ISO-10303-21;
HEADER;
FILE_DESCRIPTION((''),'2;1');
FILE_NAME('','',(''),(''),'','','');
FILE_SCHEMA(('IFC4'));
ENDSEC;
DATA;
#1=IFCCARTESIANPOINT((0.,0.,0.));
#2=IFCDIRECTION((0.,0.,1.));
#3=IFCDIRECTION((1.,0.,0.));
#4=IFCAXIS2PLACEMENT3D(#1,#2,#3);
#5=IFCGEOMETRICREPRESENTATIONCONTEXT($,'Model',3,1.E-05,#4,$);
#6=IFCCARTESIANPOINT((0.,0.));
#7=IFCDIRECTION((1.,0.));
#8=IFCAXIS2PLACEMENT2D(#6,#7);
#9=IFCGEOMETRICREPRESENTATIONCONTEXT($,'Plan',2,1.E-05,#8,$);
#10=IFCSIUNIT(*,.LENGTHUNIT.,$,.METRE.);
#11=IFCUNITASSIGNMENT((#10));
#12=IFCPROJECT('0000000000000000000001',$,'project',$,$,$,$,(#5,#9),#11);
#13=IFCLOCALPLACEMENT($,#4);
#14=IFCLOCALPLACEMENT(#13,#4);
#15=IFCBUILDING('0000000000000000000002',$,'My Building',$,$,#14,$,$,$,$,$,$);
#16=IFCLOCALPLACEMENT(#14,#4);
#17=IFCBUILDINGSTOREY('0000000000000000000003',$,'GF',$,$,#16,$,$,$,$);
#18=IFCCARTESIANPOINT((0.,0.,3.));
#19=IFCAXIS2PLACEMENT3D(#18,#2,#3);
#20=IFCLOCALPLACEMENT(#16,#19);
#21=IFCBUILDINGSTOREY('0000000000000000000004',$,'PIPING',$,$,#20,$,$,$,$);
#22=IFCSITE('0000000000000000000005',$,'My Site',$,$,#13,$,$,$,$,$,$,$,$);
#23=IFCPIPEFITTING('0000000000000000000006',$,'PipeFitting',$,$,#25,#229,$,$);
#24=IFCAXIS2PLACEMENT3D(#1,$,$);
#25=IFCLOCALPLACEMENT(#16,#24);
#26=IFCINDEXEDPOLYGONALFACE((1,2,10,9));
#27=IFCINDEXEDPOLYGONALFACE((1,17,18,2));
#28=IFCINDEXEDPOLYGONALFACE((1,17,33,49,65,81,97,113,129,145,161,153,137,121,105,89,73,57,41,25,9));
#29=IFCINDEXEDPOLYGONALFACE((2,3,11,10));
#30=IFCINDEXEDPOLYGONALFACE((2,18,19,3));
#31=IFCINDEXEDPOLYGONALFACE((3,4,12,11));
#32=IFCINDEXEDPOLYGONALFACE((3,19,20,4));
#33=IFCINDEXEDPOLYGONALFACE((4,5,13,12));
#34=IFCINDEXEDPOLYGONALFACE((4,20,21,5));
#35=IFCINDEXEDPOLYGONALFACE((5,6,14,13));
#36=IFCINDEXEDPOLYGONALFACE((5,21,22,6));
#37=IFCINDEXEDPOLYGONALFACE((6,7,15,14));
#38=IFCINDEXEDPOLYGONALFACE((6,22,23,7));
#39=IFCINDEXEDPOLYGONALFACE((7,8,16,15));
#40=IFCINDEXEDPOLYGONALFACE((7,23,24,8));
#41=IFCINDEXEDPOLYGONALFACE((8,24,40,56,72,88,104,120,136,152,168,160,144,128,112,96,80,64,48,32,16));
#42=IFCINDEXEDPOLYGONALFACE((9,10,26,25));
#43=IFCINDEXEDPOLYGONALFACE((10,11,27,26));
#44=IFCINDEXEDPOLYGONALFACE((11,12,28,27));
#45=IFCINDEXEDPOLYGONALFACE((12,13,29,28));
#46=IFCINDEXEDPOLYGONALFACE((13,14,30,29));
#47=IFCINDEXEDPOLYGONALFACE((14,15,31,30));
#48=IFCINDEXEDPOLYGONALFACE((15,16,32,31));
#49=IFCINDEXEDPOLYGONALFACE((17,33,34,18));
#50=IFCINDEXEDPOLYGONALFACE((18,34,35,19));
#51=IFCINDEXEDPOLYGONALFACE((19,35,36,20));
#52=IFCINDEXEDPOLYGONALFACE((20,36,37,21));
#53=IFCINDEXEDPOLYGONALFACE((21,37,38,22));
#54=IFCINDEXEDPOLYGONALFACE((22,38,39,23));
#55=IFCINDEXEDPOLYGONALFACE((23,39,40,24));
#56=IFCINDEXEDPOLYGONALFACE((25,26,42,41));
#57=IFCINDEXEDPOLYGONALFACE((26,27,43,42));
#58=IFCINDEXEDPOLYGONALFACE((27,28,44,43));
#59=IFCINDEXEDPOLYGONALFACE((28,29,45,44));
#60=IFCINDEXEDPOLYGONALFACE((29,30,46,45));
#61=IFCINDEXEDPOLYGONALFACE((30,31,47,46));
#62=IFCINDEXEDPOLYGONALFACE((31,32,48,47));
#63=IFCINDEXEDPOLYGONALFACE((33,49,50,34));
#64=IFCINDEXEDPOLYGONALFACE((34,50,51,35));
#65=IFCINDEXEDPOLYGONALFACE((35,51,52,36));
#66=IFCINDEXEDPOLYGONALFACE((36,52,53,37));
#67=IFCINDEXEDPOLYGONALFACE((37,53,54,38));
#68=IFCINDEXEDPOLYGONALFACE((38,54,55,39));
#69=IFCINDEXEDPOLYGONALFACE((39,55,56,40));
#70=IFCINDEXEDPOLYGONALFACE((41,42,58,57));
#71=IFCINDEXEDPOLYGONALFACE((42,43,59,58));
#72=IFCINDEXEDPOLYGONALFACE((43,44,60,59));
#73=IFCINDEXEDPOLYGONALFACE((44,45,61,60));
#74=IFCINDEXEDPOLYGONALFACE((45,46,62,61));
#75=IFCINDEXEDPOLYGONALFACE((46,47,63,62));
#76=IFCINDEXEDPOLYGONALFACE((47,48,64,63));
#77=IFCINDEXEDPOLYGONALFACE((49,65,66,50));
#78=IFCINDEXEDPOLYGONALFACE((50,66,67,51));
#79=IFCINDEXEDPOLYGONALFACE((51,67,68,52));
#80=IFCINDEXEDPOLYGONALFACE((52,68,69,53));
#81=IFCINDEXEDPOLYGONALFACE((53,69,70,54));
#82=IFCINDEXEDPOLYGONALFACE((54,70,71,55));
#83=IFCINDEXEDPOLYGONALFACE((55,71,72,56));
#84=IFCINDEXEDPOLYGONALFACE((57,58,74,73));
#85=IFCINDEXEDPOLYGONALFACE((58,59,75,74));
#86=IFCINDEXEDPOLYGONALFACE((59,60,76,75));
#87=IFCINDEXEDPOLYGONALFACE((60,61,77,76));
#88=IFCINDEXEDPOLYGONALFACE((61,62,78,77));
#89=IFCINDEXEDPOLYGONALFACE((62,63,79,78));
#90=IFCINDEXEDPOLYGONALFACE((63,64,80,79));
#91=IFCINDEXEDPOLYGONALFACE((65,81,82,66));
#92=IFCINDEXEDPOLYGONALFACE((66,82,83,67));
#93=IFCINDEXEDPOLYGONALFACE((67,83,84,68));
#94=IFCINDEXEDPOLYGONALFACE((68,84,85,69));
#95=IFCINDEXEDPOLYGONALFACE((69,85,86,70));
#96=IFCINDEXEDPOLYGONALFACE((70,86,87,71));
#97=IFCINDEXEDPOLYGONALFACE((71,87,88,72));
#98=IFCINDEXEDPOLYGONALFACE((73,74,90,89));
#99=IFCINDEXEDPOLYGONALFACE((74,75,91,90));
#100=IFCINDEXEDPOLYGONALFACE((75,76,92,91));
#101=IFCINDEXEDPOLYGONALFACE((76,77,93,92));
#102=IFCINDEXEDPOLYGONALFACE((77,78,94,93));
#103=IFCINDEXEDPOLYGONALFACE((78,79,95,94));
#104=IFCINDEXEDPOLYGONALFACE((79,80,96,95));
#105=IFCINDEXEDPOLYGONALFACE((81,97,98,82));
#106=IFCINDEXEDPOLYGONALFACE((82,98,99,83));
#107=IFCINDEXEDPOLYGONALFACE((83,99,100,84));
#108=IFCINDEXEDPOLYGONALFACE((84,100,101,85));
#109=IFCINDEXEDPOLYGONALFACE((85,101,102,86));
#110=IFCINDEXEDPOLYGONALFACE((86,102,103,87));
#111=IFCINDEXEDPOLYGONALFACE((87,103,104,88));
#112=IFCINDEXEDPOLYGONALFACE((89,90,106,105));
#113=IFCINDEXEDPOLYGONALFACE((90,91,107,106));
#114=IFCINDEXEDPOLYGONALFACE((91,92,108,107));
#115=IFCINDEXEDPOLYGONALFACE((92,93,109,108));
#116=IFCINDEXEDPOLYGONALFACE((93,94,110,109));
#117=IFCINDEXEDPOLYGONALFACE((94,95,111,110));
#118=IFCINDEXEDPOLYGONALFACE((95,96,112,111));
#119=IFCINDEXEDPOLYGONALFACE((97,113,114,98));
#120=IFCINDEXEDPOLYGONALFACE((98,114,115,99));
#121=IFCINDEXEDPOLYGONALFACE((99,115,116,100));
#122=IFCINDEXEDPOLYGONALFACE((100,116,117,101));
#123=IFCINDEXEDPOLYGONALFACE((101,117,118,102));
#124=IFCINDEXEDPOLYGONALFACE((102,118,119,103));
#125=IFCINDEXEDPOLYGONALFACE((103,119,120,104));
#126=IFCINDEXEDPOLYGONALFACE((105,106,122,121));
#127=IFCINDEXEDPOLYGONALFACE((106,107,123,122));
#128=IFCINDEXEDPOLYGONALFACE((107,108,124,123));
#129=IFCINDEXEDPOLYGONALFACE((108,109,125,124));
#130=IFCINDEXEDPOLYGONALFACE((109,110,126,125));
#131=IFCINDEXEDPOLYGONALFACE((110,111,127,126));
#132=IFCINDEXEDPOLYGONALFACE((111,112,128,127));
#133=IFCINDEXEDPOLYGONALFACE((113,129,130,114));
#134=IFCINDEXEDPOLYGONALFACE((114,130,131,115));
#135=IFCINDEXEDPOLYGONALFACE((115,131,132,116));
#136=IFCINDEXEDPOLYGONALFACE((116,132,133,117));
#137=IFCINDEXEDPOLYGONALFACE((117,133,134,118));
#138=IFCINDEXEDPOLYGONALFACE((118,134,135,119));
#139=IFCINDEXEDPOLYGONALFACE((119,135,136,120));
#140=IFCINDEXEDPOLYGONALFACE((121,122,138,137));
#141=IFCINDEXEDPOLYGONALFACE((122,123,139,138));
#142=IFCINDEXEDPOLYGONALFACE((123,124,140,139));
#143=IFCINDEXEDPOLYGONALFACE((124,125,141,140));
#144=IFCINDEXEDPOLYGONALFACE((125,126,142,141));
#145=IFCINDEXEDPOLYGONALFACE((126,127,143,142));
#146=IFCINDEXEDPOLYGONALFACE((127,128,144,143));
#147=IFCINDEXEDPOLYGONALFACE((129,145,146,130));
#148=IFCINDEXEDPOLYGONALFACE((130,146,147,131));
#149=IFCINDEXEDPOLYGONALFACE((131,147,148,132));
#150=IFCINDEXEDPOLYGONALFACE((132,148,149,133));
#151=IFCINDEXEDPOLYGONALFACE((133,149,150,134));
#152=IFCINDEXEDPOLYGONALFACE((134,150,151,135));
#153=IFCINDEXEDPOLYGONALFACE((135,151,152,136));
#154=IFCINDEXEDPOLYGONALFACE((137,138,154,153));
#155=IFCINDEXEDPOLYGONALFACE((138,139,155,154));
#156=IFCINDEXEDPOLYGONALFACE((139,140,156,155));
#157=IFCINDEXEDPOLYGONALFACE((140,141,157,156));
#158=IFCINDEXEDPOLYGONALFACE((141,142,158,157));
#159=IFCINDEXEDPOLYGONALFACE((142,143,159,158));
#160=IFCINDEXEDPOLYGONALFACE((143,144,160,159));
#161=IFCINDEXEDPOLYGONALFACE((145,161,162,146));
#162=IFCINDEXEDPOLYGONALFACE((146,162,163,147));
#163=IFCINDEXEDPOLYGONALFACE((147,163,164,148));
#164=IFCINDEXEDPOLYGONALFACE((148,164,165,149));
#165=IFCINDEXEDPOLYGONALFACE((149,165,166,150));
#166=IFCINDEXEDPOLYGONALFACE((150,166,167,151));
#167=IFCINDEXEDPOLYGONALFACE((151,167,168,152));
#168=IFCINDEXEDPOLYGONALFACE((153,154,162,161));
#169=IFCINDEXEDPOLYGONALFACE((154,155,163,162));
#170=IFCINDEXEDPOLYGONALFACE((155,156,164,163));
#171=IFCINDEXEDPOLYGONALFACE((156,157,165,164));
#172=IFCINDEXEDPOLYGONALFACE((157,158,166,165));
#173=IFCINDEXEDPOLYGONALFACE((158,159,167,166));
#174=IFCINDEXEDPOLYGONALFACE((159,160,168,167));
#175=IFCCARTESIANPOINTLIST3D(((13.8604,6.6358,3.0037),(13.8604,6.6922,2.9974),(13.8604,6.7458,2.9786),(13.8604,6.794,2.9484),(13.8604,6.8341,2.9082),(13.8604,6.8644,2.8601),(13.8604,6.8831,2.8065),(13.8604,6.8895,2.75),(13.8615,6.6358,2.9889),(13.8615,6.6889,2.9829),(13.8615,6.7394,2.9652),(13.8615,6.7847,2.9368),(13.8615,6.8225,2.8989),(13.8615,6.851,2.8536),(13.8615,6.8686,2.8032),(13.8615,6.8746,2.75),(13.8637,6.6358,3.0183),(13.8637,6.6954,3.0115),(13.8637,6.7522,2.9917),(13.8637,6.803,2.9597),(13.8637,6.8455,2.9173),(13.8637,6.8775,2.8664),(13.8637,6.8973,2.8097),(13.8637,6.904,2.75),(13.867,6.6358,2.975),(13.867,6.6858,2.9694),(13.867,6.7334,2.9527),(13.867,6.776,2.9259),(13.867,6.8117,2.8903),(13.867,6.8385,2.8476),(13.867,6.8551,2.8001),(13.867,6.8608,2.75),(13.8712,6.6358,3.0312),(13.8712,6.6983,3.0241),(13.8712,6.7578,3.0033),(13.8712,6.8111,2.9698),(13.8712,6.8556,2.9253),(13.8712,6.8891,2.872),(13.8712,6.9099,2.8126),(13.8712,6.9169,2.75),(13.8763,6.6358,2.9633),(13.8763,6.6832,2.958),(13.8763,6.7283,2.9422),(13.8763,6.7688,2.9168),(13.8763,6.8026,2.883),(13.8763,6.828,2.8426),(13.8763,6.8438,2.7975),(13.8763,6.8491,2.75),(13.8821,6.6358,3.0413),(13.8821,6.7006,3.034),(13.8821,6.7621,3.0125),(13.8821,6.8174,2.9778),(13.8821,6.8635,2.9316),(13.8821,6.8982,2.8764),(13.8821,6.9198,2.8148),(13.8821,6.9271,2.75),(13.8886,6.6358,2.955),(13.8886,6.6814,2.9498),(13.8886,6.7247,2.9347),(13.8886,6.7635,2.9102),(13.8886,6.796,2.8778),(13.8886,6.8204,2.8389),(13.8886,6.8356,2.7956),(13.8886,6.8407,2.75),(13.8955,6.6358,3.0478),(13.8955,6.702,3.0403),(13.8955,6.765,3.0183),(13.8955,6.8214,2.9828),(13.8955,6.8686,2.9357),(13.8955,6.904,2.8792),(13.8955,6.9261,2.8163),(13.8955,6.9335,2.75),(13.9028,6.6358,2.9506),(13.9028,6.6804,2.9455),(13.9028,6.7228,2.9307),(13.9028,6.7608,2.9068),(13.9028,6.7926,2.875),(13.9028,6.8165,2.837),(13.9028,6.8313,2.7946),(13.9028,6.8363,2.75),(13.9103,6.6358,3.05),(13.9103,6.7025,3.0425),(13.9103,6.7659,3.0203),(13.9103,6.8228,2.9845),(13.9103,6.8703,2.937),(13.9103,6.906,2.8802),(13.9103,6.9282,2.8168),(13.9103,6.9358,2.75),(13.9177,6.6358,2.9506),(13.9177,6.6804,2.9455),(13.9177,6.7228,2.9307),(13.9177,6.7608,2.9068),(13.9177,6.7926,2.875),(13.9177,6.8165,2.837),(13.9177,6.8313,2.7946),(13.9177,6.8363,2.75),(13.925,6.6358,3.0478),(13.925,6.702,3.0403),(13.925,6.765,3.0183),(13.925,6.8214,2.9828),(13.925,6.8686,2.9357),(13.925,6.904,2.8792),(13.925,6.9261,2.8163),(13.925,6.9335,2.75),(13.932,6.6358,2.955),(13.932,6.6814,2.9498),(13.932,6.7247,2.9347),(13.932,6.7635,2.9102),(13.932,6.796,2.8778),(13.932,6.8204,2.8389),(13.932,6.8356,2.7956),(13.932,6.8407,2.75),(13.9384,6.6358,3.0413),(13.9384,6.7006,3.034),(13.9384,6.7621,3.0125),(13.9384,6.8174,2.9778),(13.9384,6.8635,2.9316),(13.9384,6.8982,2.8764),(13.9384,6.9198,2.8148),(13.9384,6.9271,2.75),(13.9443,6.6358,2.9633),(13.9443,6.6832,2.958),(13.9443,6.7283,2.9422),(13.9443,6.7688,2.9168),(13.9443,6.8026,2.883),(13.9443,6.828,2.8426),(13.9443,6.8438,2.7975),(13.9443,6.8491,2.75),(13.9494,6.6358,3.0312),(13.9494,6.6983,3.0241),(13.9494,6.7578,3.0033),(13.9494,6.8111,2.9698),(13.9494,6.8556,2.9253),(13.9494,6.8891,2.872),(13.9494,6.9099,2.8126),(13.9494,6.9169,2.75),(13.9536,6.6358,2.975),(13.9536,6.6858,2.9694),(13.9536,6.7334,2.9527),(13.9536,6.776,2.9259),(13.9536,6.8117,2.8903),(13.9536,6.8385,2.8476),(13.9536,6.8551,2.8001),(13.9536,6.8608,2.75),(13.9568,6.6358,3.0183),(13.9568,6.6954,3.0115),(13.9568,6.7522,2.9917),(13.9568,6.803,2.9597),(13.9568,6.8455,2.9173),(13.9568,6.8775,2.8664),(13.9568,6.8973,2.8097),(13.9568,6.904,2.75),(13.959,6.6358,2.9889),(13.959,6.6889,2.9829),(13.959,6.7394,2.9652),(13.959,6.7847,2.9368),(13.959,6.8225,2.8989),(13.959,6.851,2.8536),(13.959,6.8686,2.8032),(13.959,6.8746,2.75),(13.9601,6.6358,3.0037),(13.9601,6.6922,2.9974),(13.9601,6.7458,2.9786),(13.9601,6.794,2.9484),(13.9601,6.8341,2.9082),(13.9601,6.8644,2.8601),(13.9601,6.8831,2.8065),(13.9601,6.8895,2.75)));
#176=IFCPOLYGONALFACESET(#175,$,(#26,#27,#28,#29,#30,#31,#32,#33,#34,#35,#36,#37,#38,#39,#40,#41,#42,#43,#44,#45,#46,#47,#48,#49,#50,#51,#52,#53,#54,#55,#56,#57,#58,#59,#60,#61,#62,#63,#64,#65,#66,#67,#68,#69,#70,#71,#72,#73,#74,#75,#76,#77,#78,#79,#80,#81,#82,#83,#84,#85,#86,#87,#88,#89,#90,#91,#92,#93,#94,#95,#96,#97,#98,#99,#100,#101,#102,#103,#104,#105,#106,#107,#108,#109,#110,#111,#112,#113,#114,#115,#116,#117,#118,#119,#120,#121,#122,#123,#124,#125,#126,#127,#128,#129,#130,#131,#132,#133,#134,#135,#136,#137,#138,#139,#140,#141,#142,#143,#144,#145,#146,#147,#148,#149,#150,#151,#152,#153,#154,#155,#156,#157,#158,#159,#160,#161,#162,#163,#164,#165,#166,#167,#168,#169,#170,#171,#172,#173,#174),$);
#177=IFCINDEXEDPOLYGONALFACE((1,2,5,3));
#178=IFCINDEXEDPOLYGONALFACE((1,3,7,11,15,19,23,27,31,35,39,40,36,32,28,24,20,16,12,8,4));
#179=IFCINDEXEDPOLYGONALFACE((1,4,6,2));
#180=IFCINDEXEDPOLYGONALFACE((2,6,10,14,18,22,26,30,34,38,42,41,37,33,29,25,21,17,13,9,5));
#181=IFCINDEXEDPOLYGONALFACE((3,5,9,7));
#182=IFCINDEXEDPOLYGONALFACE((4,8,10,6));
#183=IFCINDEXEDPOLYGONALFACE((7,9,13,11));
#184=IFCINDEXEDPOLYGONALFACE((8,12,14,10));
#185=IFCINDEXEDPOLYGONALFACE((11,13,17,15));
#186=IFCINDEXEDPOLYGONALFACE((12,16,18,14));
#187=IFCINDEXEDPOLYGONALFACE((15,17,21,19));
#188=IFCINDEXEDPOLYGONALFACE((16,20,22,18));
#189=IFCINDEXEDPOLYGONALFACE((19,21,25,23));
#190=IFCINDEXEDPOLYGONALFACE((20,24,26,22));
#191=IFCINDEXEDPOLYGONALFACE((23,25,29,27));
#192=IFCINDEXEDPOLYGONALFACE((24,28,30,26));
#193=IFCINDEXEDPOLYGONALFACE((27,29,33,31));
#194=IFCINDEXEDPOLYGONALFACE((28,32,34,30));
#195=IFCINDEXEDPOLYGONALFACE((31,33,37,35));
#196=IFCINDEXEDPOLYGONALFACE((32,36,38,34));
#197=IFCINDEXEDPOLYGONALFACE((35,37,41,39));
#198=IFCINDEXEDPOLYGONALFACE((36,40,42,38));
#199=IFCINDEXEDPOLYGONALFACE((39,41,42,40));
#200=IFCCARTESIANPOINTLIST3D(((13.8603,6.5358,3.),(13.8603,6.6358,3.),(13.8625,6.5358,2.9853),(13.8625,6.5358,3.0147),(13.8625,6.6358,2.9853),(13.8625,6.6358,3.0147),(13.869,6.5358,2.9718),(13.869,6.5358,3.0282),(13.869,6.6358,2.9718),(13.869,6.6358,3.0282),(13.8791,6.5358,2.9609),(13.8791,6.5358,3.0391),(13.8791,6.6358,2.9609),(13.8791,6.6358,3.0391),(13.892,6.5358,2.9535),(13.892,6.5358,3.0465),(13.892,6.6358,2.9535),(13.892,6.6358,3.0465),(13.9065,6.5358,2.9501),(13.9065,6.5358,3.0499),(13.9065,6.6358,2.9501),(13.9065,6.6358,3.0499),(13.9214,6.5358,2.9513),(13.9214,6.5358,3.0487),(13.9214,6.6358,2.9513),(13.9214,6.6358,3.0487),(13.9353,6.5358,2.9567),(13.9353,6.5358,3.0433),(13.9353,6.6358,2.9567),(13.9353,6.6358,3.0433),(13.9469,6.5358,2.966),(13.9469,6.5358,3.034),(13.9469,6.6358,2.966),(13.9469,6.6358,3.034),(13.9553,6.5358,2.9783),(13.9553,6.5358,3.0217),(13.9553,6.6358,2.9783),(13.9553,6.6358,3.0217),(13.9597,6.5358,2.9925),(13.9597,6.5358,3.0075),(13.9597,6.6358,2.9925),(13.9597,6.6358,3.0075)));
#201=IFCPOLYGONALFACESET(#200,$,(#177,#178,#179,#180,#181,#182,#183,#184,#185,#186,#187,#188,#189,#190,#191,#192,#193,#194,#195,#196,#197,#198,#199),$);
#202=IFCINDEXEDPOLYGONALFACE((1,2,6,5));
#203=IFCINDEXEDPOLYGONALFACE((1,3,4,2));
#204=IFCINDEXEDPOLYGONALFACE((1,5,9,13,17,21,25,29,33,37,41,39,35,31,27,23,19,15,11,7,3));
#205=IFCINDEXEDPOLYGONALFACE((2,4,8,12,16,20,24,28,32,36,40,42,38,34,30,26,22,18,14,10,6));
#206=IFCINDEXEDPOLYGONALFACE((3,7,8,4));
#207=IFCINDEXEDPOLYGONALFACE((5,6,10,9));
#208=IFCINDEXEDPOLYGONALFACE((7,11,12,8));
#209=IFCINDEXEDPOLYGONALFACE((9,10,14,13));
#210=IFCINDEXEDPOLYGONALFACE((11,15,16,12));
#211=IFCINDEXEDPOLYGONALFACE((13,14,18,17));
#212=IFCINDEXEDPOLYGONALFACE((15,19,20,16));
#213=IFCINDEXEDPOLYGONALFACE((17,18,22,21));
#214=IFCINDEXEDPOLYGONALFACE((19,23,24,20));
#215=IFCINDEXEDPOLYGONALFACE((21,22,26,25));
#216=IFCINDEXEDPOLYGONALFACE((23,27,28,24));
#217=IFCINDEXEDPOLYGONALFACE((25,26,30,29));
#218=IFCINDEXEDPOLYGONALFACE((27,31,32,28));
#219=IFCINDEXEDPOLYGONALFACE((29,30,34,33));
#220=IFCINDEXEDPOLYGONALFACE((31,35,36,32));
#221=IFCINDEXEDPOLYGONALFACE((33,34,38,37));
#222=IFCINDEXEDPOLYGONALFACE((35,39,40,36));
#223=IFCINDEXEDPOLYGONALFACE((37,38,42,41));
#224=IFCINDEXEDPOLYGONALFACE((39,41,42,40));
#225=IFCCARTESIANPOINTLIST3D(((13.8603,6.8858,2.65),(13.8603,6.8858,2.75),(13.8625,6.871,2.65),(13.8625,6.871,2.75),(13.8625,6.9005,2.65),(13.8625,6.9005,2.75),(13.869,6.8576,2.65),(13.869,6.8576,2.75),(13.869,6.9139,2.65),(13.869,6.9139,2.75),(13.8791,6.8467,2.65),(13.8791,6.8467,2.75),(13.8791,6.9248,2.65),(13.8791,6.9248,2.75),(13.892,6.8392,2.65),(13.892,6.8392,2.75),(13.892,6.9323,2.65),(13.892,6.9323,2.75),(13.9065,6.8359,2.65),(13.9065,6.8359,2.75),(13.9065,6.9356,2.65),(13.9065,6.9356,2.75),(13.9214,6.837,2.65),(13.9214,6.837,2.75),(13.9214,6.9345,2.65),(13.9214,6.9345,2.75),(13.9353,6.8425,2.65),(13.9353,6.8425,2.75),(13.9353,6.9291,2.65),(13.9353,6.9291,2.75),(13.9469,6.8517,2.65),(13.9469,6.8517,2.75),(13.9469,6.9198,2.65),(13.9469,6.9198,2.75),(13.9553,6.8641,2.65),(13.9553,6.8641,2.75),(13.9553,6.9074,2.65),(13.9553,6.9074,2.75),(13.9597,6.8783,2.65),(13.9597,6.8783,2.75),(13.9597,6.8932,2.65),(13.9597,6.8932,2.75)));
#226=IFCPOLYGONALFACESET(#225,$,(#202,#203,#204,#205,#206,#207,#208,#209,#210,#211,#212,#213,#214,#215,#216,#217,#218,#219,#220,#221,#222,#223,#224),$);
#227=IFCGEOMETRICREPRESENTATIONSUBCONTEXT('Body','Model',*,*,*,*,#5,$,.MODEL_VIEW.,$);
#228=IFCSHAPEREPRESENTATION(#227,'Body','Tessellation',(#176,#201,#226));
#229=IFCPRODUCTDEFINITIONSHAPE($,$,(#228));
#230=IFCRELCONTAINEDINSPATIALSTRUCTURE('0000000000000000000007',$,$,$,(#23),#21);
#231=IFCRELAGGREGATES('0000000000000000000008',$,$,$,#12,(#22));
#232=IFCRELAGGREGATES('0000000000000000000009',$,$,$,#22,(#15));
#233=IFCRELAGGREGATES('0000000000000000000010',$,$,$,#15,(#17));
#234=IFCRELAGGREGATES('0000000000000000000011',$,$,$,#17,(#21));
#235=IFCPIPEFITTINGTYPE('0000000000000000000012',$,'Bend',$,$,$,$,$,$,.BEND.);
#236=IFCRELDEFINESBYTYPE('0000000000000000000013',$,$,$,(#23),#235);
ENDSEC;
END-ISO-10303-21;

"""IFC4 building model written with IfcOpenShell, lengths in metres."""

from ifc_helpers import new_model, entity, si_unit, frame, origin_with_axes, origin_2d_with_axis, place, context, subcontext, project, spatial, circle, extrude, source, transform, mapped, type_object, type_shapes, element, save


model = new_model("IFC4")

# Units and contexts
model_context = context("Model", 3, precision=1e-05, world=origin_with_axes())
plan_context = context("Plan", 2, precision=1e-05, world=origin_2d_with_axis())
body_context = subcontext(model_context, "Body", "Model", "MODEL_VIEW")
ifc_project = project(units=[si_unit("LENGTHUNIT", "METRE")], contexts=[model_context, plan_context])

# Site, building, storeys
site_placement = place(None, origin_with_axes())
site = spatial("IfcSite", under=ifc_project, at=site_placement, Name="My Site")
building_placement = place(site_placement, origin_with_axes())
building = spatial("IfcBuilding", under=site, at=building_placement, Name="My Building")
storey_1_placement = place(building_placement, origin_with_axes())
storey_1 = spatial("IfcBuildingStorey", under=building, at=storey_1_placement, Name="GF")
storey_2_placement = place(storey_1_placement, frame((0.0, 0.0, 3.0), z_axis=(0.0, 0.0, 1.0), x_axis=(1.0, 0.0, 0.0)))
storey_2 = spatial("IfcBuildingStorey", under=storey_1, at=storey_2_placement, Name="PIPING")

# Pipe fitting
pipe_fitting_type = type_object("IfcPipeFittingType", Name="Bend", PredefinedType="BEND")
shared_shape = source(origin_with_axes(), body_context, "Body", "SolidModel", [
    entity("IfcSweptDiskSolid", entity("IfcIndexedPolyCurve", entity("IfcCartesianPointList3D", [[0.0, 0.0, -0.1], [0.0, 0.0732, -0.2768], [0.0, 0.25, -0.35]]), [entity("IfcArcIndex", [1, 2, 3])]), 0.05),
    extrude(circle(Radius=0.05), origin_with_axes(), (0.0, 0.0, -1.0), 0.1),
    extrude(circle(Radius=0.05), frame((0.0, 0.25, -0.35), z_axis=(0.0, 1.0, 0.0), x_axis=(1.0, 0.0, 0.0)), (0.0, 0.0, 1.0), 0.1),
])
type_shapes(pipe_fitting_type, [shared_shape])
for number, where, z_axis, x_axis, name in (
    (1, (13.9103, 6.5358, 0.0), (0.0, -1.0, 0.0), (-1.0, 0.0, 0.0), "PipeFitting"),
):
    element("IfcPipeFitting", number, at=place(storey_2_placement, frame(where, z_axis=z_axis, x_axis=x_axis)), inside=storey_2, type_object=pipe_fitting_type, Name=name, context=body_context, shape_type="MappedRepresentation", body=[
        mapped(shared_shape, transform((0.0, 0.0, 0.0), x_axis=(1.0, 0.0, 0.0), y_axis=(0.0, 1.0, 0.0), z_axis=(0.0, 0.0, 1.0), scale=1.0)),
    ])

save(model, "model.ifc")
